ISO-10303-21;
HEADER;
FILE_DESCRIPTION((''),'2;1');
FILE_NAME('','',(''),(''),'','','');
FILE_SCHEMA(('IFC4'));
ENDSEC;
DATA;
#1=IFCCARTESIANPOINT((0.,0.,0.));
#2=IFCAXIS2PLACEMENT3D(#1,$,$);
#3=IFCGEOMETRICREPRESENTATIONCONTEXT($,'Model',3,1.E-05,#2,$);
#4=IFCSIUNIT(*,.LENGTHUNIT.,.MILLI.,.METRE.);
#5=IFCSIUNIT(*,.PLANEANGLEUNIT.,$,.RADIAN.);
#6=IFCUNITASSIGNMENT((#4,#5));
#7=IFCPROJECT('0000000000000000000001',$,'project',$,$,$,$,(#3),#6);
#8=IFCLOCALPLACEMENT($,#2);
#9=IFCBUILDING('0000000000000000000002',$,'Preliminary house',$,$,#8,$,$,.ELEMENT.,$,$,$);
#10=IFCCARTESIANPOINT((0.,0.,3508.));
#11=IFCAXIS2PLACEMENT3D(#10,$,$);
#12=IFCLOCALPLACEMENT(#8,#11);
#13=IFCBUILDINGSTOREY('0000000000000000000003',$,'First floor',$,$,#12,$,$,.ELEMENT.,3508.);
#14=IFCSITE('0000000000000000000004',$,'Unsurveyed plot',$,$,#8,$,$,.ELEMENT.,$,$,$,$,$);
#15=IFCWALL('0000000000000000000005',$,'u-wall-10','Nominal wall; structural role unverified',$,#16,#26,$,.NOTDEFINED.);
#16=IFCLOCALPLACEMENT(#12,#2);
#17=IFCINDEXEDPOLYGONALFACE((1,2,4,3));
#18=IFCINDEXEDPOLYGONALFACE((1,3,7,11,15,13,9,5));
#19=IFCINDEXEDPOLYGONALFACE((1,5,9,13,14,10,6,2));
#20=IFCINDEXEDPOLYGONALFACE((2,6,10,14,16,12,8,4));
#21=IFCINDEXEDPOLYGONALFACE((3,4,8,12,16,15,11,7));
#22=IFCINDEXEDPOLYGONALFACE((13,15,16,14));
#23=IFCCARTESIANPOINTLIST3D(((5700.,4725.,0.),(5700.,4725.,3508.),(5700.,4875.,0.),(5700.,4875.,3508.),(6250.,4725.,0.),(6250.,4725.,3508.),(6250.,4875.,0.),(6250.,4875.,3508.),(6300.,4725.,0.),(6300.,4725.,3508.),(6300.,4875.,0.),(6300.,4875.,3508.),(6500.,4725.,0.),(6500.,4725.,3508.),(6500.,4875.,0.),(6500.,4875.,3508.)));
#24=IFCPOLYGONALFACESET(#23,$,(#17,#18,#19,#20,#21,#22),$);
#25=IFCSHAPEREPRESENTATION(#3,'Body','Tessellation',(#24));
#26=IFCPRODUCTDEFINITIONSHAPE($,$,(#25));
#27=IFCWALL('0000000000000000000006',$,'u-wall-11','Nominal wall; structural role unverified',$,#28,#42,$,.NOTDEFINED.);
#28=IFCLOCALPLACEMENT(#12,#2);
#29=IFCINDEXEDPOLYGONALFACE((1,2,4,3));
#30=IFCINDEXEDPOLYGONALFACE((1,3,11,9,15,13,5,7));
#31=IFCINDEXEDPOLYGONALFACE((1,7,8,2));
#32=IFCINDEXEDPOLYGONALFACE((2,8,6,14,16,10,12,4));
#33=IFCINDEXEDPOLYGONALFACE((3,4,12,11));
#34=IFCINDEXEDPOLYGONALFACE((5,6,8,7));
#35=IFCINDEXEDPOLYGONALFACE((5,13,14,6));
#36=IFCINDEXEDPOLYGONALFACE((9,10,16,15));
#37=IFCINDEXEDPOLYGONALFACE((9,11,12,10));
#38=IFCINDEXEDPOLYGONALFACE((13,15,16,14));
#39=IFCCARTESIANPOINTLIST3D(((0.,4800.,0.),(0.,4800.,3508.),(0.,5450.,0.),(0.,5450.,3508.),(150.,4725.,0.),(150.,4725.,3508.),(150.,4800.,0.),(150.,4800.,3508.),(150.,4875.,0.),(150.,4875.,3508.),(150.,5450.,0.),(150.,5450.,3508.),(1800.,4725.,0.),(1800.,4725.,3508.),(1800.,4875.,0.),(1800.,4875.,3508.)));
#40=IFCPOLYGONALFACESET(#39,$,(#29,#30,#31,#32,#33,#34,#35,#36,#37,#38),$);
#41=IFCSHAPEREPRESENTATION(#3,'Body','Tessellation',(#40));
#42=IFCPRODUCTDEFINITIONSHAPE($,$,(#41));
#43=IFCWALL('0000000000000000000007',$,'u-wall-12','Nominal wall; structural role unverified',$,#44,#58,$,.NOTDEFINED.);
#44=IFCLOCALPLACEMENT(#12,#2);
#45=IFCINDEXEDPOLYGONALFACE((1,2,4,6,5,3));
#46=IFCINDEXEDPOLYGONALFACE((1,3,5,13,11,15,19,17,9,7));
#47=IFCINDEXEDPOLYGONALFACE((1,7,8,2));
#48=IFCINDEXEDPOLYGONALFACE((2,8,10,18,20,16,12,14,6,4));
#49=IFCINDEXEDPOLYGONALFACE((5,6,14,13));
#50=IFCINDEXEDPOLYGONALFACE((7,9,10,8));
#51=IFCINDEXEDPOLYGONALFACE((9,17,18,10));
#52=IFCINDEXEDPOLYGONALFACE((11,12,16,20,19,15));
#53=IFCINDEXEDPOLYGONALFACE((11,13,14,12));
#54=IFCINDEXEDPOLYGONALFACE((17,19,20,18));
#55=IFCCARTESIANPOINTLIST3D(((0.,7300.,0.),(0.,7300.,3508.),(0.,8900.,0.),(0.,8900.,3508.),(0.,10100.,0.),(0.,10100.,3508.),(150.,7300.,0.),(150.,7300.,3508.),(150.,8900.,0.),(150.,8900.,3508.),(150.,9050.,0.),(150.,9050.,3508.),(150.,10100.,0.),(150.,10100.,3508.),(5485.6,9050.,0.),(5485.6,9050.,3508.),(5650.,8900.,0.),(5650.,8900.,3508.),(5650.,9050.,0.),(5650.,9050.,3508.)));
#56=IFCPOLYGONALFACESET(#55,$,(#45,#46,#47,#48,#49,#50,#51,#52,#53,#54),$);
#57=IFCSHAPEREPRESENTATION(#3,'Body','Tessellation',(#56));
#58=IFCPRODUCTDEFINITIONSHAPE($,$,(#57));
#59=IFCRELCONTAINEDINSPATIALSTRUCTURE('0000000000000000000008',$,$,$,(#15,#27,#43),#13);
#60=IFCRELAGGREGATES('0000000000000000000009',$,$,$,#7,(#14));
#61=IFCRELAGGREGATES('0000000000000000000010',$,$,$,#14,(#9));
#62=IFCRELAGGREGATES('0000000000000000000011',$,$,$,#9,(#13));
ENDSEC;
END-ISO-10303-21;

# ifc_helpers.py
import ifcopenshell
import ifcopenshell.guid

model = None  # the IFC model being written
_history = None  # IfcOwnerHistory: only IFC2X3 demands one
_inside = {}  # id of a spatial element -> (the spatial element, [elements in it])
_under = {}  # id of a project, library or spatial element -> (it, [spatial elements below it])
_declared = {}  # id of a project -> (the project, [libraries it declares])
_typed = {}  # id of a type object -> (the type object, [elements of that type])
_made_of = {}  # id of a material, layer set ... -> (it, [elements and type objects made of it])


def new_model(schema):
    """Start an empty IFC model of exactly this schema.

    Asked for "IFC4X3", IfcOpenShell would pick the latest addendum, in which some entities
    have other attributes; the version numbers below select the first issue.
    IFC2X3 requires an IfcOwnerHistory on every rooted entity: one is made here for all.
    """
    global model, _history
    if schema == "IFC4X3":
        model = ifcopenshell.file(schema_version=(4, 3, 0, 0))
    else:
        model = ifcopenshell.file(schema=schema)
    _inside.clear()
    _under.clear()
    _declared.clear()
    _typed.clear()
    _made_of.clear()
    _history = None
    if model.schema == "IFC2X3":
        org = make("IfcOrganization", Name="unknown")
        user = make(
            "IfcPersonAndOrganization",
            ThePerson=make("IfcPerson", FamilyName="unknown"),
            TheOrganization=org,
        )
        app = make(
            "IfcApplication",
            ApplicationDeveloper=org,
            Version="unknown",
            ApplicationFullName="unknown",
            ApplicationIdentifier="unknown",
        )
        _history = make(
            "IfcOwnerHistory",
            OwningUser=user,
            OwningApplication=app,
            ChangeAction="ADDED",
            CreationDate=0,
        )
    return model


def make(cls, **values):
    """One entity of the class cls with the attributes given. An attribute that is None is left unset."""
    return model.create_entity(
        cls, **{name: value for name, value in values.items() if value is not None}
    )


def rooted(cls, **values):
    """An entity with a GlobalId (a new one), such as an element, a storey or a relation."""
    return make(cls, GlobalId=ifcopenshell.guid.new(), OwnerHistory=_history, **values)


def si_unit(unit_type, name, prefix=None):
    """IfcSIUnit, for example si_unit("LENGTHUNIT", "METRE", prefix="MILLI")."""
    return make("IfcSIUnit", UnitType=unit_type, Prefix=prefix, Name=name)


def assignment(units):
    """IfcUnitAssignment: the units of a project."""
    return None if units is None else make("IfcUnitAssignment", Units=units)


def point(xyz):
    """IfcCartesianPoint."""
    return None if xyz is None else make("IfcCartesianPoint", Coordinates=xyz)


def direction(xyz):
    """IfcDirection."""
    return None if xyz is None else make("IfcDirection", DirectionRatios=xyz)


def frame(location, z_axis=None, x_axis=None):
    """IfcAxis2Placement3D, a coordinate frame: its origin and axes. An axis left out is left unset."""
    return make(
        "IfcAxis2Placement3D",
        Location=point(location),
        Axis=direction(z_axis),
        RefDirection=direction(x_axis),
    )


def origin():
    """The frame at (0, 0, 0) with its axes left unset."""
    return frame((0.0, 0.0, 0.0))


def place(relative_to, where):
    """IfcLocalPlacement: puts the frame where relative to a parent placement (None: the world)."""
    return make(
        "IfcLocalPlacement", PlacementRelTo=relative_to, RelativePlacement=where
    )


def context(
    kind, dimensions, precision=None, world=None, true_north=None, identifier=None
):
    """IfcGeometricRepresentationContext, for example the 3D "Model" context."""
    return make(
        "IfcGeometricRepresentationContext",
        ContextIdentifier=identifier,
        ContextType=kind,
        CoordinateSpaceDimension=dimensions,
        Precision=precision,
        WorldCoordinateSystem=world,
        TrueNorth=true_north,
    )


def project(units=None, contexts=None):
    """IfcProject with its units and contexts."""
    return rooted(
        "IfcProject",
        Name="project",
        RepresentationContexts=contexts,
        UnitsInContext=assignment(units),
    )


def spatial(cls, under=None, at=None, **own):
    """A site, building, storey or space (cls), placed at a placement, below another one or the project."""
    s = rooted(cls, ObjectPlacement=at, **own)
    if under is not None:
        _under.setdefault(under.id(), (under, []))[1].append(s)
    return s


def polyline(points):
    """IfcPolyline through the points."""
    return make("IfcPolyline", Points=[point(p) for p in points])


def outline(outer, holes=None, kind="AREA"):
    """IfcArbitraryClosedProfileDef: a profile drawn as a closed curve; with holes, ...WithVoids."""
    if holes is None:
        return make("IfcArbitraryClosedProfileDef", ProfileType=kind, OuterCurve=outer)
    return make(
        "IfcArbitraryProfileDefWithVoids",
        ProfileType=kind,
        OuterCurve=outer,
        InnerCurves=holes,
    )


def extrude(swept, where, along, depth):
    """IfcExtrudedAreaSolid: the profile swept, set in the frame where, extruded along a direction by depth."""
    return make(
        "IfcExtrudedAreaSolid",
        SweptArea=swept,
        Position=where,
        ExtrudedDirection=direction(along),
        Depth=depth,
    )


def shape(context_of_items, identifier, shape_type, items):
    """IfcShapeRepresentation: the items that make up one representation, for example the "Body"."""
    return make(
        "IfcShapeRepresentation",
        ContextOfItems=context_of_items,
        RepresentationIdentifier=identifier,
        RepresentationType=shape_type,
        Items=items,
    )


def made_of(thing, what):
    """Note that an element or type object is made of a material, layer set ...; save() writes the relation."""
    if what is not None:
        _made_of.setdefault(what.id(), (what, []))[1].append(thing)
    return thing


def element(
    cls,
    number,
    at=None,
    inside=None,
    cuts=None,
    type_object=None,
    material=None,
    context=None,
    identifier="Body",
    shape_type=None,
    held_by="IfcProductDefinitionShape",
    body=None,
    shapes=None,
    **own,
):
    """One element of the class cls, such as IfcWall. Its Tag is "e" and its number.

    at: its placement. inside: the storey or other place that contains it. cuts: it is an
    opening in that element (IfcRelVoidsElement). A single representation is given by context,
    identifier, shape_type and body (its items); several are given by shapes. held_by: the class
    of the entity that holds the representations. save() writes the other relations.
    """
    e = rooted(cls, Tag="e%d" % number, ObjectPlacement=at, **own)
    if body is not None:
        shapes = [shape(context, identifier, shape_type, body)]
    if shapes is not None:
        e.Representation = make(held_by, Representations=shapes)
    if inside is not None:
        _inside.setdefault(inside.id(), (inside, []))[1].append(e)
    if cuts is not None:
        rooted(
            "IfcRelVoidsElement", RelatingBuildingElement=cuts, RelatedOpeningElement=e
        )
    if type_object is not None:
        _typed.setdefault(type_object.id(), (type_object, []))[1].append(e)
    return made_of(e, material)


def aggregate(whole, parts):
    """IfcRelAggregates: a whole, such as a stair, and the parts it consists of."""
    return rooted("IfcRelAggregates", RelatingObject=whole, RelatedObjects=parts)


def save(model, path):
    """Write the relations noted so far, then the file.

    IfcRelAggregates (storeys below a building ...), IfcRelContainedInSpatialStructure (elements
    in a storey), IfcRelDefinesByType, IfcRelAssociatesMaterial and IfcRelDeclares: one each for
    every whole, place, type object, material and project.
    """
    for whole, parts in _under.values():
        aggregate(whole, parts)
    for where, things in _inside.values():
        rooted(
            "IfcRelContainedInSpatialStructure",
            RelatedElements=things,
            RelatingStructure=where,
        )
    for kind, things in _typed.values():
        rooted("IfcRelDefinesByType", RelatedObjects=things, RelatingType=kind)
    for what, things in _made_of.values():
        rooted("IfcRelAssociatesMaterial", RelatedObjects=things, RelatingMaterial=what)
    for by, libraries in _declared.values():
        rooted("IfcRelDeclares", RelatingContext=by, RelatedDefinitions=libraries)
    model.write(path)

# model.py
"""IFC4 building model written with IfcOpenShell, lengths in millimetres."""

from ifc_helpers import new_model, si_unit, frame, origin, place, context, project, spatial, polyline, outline, extrude, element, save


model = new_model("IFC4")

# Units and contexts
model_context = context("Model", 3, precision=1e-05, world=origin())
ifc_project = project(units=[si_unit("LENGTHUNIT", "METRE", prefix="MILLI"), si_unit("PLANEANGLEUNIT", "RADIAN")], contexts=[model_context])

# Site, building, storey
placement_1 = place(None, origin())
site = spatial("IfcSite", under=ifc_project, at=placement_1, Name="Unsurveyed plot", CompositionType="ELEMENT")
building = spatial("IfcBuilding", under=site, at=placement_1, Name="Preliminary house", CompositionType="ELEMENT")
placement_2 = place(placement_1, frame((0.0, 0.0, 3508.0)))
storey = spatial("IfcBuildingStorey", under=building, at=placement_2, Name="First floor", CompositionType="ELEMENT", Elevation=3508.0)

# Walls
element("IfcWall", 1, at=placement_2, inside=storey, Name="u-wall-10", Description="Nominal wall; structural role unverified", PredefinedType="NOTDEFINED", context=model_context, shape_type="SweptSolid", body=[
    extrude(outline(polyline([(6300.0, 4725.0), (6250.0, 4725.0), (5700.0, 4725.0), (5700.0, 4875.0), (6250.0, 4875.0), (6300.0, 4875.0), (6500.0, 4875.0), (6500.0, 4725.0), (6300.0, 4725.0)])), origin(), (0.0, 0.0, 1.0), 3508.0),
])
element("IfcWall", 2, at=placement_2, inside=storey, Name="u-wall-11", Description="Nominal wall; structural role unverified", PredefinedType="NOTDEFINED", context=model_context, shape_type="SweptSolid", body=[
    extrude(outline(polyline([(150.0, 4800.0), (0.0, 4800.0), (0.0, 5450.0), (150.0, 5450.0), (150.0, 4875.0), (1800.0, 4875.0), (1800.0, 4725.0), (150.0, 4725.0), (150.0, 4800.0)])), origin(), (0.0, 0.0, 1.0), 3508.0),
])
element("IfcWall", 3, at=placement_2, inside=storey, Name="u-wall-12", Description="Nominal wall; structural role unverified", PredefinedType="NOTDEFINED", context=model_context, shape_type="SweptSolid", body=[
    extrude(outline(polyline([(0.0, 8900.0), (0.0, 10100.0), (150.0, 10100.0), (150.0, 9050.0), (5485.6, 9050.0), (5650.0, 9050.0), (5650.0, 8900.0), (150.0, 8900.0), (150.0, 7300.0), (0.0, 7300.0), (0.0, 8900.0)])), origin(), (0.0, 0.0, 1.0), 3508.0),
])

save(model, "model.ifc")
